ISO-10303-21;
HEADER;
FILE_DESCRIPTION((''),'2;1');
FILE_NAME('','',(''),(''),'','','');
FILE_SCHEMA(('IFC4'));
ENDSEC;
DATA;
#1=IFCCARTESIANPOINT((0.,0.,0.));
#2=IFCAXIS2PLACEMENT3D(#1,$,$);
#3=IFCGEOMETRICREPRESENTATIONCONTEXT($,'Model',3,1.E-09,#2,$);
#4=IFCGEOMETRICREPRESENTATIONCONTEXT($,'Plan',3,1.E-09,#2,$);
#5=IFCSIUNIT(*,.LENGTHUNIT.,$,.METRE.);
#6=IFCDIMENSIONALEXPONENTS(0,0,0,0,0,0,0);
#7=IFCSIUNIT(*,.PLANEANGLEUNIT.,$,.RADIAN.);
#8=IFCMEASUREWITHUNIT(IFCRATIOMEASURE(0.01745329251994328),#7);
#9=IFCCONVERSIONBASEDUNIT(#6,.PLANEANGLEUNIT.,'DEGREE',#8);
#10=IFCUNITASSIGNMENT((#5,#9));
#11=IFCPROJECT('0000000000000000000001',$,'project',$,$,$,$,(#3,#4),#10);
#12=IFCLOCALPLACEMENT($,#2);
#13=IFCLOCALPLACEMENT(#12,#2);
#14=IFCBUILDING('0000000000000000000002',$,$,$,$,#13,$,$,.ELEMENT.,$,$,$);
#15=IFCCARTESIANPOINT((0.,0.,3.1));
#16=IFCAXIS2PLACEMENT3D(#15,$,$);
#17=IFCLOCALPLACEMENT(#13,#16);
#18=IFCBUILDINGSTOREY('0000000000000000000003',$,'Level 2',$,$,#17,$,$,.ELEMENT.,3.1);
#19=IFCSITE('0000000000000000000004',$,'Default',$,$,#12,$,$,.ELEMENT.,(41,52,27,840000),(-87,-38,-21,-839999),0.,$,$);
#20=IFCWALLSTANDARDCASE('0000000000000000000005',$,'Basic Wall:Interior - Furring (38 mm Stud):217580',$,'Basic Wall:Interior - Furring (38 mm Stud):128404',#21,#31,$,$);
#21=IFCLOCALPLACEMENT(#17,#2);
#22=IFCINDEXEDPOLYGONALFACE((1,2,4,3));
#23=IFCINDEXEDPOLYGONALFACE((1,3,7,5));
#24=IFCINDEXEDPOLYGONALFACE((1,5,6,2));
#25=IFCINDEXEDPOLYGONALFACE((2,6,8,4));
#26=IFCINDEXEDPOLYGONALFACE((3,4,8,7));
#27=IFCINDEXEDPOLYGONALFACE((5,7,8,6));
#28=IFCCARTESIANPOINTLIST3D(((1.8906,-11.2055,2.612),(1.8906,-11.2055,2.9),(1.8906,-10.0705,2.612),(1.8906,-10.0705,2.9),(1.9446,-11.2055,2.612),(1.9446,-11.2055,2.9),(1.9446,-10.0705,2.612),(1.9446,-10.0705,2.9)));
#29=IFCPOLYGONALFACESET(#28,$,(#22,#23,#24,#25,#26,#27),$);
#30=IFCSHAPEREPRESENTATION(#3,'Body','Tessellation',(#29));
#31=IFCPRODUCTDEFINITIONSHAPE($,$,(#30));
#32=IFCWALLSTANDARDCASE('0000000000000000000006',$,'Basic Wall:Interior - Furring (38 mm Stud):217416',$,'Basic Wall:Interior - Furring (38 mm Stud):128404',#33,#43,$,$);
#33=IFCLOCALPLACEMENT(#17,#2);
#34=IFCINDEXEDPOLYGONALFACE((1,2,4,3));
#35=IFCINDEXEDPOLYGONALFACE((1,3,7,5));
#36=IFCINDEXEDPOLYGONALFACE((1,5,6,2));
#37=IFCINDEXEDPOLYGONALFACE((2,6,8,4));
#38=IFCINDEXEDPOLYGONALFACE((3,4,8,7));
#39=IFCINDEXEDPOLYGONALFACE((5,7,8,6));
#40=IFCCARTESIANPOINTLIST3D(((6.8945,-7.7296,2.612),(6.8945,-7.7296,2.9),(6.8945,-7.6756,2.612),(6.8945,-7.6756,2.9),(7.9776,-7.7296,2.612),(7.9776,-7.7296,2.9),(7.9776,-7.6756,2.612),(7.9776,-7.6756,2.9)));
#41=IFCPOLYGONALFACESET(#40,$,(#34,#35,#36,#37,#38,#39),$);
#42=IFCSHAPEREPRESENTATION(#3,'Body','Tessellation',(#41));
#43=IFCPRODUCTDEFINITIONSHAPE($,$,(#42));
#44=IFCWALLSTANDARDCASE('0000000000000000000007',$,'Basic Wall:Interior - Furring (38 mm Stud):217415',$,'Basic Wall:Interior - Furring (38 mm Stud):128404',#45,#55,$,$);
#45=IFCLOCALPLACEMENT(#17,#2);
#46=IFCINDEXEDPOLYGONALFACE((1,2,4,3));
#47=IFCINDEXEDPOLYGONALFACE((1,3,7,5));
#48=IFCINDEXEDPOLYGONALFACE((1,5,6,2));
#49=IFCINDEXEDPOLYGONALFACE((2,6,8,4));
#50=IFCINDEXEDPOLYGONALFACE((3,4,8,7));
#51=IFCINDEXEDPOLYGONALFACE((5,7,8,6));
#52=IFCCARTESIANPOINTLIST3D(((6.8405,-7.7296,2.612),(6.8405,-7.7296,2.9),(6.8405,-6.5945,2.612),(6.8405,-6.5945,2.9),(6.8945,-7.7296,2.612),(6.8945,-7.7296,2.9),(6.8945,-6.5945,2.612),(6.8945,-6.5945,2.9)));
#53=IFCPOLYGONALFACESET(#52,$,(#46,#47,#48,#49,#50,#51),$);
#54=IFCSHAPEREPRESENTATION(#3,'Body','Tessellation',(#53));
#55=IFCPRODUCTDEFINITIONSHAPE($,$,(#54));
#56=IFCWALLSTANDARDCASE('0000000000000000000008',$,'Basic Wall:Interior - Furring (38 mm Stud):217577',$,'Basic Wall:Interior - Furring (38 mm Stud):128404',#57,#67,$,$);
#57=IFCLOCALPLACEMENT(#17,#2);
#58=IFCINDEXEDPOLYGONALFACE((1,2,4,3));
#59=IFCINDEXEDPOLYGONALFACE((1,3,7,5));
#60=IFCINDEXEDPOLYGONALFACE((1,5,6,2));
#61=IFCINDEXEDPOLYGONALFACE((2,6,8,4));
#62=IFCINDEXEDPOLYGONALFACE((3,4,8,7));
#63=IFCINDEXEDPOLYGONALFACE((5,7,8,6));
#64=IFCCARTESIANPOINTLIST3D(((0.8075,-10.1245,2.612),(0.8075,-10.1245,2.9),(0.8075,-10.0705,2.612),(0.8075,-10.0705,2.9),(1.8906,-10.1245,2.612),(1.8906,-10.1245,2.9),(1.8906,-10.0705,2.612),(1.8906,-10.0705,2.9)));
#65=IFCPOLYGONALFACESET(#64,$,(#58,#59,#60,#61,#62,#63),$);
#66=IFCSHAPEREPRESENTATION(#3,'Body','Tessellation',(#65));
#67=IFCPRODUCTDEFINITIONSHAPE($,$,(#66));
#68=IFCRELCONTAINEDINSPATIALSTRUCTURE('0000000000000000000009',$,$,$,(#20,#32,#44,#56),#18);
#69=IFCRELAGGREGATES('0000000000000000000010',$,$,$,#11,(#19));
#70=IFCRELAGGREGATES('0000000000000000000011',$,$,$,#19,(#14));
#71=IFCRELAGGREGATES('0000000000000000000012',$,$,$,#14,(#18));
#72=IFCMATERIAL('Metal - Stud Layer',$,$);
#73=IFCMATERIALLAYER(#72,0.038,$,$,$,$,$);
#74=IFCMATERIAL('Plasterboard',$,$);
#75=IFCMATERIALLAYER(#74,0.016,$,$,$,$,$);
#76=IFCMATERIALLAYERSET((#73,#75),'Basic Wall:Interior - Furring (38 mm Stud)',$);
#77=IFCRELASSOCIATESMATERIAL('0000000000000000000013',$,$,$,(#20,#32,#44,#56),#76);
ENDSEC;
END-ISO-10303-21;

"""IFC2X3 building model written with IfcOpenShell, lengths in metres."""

from ifc_helpers import new_model, entity, si_unit, converted_unit, frame, frame_2d, origin, place, context, project, spatial, rectangle, extrude, material, layer, layer_set, layer_usage, element, save


model = new_model("IFC2X3")

# Units and contexts
model_context = context("Model", 3, precision=1e-09, world=origin())
plan_context = context("Plan", 3, precision=1e-09, world=origin())
ifc_project = project(units=[si_unit("LENGTHUNIT", "METRE"), converted_unit("PLANEANGLEUNIT", "DEGREE", entity("IfcRatioMeasure", 0.01745329251994328), si_unit("PLANEANGLEUNIT", "RADIAN"), dimensions=[0, 0, 0, 0, 0, 0, 0])], contexts=[model_context, plan_context])

# Site, building, storey
site_placement = place(None, origin())
site = spatial("IfcSite", under=ifc_project, at=site_placement, Name="Default", CompositionType="ELEMENT", RefLatitude=(41, 52, 27, 840000), RefLongitude=(-87, -38, -21, -839999), RefElevation=0.0)
building_placement = place(site_placement, origin())
building = spatial("IfcBuilding", under=site, at=building_placement, CompositionType="ELEMENT")
storey_placement = place(building_placement, frame((0.0, 0.0, 3.1)))
storey = spatial("IfcBuildingStorey", under=building, at=storey_placement, Name="Level 2", CompositionType="ELEMENT", Elevation=3.1)

# Shared definitions
ifc_material_1 = material(Name="Plasterboard")
ifc_material_2 = material(Name="Metal - Stud Layer")

# Walls
ifc_layer_1 = layer(ifc_material_2, 0.038)
ifc_layer_2 = layer(ifc_material_1, 0.016)
ifc_layer_set_1 = layer_set([ifc_layer_1, ifc_layer_2], Name="Basic Wall:Interior - Furring (38 mm Stud)")
ifc_layer_usage_1 = layer_usage(ifc_layer_set_1, "AXIS2", "NEGATIVE", 0.027)
wall_1_placement = place(storey_placement, frame((1.9176, -10.0705, 2.612), z_axis=(0.0, 0.0, 1.0), x_axis=(0.0, -1.0, 0.0)))
element("IfcWallStandardCase", 1, at=wall_1_placement, inside=storey, material=ifc_layer_usage_1, Name="Basic Wall:Interior - Furring (38 mm Stud):217580", ObjectType="Basic Wall:Interior - Furring (38 mm Stud):128404", context=model_context, shape_type="SweptSolid", body=[
    extrude(rectangle(XDim=1.1351, YDim=0.054, at=frame_2d((0.5675, 0.0), x_axis=(-1.0, 0.0))), origin(), (0.0, 0.0, 1.0), 0.288),
])
wall_2_placement = place(storey_placement, frame((7.9776, -7.7026, 2.612), z_axis=(0.0, 0.0, 1.0), x_axis=(-1.0, 0.0, 0.0)))
element("IfcWallStandardCase", 2, at=wall_2_placement, inside=storey, material=ifc_layer_usage_1, Name="Basic Wall:Interior - Furring (38 mm Stud):217416", ObjectType="Basic Wall:Interior - Furring (38 mm Stud):128404", context=model_context, shape_type="SweptSolid", body=[
    extrude(rectangle(XDim=1.0831, YDim=0.054, at=frame_2d((0.5416, 0.0), x_axis=(-1.0, 0.0))), origin(), (0.0, 0.0, 1.0), 0.288),
])
wall_3_placement = place(storey_placement, frame((6.8675, -7.7296, 2.612), z_axis=(0.0, 0.0, 1.0), x_axis=(0.0, 1.0, 0.0)))
element("IfcWallStandardCase", 3, at=wall_3_placement, inside=storey, material=ifc_layer_usage_1, Name="Basic Wall:Interior - Furring (38 mm Stud):217415", ObjectType="Basic Wall:Interior - Furring (38 mm Stud):128404", context=model_context, shape_type="SweptSolid", body=[
    extrude(rectangle(XDim=1.1351, YDim=0.054, at=frame_2d((0.5675, 0.0), x_axis=(-1.0, 0.0))), origin(), (0.0, 0.0, 1.0), 0.288),
])
wall_4_placement = place(storey_placement, frame((0.8075, -10.0975, 2.612)))
element("IfcWallStandardCase", 4, at=wall_4_placement, inside=storey, material=ifc_layer_usage_1, Name="Basic Wall:Interior - Furring (38 mm Stud):217577", ObjectType="Basic Wall:Interior - Furring (38 mm Stud):128404", context=model_context, shape_type="SweptSolid", body=[
    extrude(rectangle(XDim=1.0831, YDim=0.054, at=frame_2d((0.5415, 0.0), x_axis=(-1.0, 0.0))), origin(), (0.0, 0.0, 1.0), 0.288),
])

save(model, "model.ifc")
